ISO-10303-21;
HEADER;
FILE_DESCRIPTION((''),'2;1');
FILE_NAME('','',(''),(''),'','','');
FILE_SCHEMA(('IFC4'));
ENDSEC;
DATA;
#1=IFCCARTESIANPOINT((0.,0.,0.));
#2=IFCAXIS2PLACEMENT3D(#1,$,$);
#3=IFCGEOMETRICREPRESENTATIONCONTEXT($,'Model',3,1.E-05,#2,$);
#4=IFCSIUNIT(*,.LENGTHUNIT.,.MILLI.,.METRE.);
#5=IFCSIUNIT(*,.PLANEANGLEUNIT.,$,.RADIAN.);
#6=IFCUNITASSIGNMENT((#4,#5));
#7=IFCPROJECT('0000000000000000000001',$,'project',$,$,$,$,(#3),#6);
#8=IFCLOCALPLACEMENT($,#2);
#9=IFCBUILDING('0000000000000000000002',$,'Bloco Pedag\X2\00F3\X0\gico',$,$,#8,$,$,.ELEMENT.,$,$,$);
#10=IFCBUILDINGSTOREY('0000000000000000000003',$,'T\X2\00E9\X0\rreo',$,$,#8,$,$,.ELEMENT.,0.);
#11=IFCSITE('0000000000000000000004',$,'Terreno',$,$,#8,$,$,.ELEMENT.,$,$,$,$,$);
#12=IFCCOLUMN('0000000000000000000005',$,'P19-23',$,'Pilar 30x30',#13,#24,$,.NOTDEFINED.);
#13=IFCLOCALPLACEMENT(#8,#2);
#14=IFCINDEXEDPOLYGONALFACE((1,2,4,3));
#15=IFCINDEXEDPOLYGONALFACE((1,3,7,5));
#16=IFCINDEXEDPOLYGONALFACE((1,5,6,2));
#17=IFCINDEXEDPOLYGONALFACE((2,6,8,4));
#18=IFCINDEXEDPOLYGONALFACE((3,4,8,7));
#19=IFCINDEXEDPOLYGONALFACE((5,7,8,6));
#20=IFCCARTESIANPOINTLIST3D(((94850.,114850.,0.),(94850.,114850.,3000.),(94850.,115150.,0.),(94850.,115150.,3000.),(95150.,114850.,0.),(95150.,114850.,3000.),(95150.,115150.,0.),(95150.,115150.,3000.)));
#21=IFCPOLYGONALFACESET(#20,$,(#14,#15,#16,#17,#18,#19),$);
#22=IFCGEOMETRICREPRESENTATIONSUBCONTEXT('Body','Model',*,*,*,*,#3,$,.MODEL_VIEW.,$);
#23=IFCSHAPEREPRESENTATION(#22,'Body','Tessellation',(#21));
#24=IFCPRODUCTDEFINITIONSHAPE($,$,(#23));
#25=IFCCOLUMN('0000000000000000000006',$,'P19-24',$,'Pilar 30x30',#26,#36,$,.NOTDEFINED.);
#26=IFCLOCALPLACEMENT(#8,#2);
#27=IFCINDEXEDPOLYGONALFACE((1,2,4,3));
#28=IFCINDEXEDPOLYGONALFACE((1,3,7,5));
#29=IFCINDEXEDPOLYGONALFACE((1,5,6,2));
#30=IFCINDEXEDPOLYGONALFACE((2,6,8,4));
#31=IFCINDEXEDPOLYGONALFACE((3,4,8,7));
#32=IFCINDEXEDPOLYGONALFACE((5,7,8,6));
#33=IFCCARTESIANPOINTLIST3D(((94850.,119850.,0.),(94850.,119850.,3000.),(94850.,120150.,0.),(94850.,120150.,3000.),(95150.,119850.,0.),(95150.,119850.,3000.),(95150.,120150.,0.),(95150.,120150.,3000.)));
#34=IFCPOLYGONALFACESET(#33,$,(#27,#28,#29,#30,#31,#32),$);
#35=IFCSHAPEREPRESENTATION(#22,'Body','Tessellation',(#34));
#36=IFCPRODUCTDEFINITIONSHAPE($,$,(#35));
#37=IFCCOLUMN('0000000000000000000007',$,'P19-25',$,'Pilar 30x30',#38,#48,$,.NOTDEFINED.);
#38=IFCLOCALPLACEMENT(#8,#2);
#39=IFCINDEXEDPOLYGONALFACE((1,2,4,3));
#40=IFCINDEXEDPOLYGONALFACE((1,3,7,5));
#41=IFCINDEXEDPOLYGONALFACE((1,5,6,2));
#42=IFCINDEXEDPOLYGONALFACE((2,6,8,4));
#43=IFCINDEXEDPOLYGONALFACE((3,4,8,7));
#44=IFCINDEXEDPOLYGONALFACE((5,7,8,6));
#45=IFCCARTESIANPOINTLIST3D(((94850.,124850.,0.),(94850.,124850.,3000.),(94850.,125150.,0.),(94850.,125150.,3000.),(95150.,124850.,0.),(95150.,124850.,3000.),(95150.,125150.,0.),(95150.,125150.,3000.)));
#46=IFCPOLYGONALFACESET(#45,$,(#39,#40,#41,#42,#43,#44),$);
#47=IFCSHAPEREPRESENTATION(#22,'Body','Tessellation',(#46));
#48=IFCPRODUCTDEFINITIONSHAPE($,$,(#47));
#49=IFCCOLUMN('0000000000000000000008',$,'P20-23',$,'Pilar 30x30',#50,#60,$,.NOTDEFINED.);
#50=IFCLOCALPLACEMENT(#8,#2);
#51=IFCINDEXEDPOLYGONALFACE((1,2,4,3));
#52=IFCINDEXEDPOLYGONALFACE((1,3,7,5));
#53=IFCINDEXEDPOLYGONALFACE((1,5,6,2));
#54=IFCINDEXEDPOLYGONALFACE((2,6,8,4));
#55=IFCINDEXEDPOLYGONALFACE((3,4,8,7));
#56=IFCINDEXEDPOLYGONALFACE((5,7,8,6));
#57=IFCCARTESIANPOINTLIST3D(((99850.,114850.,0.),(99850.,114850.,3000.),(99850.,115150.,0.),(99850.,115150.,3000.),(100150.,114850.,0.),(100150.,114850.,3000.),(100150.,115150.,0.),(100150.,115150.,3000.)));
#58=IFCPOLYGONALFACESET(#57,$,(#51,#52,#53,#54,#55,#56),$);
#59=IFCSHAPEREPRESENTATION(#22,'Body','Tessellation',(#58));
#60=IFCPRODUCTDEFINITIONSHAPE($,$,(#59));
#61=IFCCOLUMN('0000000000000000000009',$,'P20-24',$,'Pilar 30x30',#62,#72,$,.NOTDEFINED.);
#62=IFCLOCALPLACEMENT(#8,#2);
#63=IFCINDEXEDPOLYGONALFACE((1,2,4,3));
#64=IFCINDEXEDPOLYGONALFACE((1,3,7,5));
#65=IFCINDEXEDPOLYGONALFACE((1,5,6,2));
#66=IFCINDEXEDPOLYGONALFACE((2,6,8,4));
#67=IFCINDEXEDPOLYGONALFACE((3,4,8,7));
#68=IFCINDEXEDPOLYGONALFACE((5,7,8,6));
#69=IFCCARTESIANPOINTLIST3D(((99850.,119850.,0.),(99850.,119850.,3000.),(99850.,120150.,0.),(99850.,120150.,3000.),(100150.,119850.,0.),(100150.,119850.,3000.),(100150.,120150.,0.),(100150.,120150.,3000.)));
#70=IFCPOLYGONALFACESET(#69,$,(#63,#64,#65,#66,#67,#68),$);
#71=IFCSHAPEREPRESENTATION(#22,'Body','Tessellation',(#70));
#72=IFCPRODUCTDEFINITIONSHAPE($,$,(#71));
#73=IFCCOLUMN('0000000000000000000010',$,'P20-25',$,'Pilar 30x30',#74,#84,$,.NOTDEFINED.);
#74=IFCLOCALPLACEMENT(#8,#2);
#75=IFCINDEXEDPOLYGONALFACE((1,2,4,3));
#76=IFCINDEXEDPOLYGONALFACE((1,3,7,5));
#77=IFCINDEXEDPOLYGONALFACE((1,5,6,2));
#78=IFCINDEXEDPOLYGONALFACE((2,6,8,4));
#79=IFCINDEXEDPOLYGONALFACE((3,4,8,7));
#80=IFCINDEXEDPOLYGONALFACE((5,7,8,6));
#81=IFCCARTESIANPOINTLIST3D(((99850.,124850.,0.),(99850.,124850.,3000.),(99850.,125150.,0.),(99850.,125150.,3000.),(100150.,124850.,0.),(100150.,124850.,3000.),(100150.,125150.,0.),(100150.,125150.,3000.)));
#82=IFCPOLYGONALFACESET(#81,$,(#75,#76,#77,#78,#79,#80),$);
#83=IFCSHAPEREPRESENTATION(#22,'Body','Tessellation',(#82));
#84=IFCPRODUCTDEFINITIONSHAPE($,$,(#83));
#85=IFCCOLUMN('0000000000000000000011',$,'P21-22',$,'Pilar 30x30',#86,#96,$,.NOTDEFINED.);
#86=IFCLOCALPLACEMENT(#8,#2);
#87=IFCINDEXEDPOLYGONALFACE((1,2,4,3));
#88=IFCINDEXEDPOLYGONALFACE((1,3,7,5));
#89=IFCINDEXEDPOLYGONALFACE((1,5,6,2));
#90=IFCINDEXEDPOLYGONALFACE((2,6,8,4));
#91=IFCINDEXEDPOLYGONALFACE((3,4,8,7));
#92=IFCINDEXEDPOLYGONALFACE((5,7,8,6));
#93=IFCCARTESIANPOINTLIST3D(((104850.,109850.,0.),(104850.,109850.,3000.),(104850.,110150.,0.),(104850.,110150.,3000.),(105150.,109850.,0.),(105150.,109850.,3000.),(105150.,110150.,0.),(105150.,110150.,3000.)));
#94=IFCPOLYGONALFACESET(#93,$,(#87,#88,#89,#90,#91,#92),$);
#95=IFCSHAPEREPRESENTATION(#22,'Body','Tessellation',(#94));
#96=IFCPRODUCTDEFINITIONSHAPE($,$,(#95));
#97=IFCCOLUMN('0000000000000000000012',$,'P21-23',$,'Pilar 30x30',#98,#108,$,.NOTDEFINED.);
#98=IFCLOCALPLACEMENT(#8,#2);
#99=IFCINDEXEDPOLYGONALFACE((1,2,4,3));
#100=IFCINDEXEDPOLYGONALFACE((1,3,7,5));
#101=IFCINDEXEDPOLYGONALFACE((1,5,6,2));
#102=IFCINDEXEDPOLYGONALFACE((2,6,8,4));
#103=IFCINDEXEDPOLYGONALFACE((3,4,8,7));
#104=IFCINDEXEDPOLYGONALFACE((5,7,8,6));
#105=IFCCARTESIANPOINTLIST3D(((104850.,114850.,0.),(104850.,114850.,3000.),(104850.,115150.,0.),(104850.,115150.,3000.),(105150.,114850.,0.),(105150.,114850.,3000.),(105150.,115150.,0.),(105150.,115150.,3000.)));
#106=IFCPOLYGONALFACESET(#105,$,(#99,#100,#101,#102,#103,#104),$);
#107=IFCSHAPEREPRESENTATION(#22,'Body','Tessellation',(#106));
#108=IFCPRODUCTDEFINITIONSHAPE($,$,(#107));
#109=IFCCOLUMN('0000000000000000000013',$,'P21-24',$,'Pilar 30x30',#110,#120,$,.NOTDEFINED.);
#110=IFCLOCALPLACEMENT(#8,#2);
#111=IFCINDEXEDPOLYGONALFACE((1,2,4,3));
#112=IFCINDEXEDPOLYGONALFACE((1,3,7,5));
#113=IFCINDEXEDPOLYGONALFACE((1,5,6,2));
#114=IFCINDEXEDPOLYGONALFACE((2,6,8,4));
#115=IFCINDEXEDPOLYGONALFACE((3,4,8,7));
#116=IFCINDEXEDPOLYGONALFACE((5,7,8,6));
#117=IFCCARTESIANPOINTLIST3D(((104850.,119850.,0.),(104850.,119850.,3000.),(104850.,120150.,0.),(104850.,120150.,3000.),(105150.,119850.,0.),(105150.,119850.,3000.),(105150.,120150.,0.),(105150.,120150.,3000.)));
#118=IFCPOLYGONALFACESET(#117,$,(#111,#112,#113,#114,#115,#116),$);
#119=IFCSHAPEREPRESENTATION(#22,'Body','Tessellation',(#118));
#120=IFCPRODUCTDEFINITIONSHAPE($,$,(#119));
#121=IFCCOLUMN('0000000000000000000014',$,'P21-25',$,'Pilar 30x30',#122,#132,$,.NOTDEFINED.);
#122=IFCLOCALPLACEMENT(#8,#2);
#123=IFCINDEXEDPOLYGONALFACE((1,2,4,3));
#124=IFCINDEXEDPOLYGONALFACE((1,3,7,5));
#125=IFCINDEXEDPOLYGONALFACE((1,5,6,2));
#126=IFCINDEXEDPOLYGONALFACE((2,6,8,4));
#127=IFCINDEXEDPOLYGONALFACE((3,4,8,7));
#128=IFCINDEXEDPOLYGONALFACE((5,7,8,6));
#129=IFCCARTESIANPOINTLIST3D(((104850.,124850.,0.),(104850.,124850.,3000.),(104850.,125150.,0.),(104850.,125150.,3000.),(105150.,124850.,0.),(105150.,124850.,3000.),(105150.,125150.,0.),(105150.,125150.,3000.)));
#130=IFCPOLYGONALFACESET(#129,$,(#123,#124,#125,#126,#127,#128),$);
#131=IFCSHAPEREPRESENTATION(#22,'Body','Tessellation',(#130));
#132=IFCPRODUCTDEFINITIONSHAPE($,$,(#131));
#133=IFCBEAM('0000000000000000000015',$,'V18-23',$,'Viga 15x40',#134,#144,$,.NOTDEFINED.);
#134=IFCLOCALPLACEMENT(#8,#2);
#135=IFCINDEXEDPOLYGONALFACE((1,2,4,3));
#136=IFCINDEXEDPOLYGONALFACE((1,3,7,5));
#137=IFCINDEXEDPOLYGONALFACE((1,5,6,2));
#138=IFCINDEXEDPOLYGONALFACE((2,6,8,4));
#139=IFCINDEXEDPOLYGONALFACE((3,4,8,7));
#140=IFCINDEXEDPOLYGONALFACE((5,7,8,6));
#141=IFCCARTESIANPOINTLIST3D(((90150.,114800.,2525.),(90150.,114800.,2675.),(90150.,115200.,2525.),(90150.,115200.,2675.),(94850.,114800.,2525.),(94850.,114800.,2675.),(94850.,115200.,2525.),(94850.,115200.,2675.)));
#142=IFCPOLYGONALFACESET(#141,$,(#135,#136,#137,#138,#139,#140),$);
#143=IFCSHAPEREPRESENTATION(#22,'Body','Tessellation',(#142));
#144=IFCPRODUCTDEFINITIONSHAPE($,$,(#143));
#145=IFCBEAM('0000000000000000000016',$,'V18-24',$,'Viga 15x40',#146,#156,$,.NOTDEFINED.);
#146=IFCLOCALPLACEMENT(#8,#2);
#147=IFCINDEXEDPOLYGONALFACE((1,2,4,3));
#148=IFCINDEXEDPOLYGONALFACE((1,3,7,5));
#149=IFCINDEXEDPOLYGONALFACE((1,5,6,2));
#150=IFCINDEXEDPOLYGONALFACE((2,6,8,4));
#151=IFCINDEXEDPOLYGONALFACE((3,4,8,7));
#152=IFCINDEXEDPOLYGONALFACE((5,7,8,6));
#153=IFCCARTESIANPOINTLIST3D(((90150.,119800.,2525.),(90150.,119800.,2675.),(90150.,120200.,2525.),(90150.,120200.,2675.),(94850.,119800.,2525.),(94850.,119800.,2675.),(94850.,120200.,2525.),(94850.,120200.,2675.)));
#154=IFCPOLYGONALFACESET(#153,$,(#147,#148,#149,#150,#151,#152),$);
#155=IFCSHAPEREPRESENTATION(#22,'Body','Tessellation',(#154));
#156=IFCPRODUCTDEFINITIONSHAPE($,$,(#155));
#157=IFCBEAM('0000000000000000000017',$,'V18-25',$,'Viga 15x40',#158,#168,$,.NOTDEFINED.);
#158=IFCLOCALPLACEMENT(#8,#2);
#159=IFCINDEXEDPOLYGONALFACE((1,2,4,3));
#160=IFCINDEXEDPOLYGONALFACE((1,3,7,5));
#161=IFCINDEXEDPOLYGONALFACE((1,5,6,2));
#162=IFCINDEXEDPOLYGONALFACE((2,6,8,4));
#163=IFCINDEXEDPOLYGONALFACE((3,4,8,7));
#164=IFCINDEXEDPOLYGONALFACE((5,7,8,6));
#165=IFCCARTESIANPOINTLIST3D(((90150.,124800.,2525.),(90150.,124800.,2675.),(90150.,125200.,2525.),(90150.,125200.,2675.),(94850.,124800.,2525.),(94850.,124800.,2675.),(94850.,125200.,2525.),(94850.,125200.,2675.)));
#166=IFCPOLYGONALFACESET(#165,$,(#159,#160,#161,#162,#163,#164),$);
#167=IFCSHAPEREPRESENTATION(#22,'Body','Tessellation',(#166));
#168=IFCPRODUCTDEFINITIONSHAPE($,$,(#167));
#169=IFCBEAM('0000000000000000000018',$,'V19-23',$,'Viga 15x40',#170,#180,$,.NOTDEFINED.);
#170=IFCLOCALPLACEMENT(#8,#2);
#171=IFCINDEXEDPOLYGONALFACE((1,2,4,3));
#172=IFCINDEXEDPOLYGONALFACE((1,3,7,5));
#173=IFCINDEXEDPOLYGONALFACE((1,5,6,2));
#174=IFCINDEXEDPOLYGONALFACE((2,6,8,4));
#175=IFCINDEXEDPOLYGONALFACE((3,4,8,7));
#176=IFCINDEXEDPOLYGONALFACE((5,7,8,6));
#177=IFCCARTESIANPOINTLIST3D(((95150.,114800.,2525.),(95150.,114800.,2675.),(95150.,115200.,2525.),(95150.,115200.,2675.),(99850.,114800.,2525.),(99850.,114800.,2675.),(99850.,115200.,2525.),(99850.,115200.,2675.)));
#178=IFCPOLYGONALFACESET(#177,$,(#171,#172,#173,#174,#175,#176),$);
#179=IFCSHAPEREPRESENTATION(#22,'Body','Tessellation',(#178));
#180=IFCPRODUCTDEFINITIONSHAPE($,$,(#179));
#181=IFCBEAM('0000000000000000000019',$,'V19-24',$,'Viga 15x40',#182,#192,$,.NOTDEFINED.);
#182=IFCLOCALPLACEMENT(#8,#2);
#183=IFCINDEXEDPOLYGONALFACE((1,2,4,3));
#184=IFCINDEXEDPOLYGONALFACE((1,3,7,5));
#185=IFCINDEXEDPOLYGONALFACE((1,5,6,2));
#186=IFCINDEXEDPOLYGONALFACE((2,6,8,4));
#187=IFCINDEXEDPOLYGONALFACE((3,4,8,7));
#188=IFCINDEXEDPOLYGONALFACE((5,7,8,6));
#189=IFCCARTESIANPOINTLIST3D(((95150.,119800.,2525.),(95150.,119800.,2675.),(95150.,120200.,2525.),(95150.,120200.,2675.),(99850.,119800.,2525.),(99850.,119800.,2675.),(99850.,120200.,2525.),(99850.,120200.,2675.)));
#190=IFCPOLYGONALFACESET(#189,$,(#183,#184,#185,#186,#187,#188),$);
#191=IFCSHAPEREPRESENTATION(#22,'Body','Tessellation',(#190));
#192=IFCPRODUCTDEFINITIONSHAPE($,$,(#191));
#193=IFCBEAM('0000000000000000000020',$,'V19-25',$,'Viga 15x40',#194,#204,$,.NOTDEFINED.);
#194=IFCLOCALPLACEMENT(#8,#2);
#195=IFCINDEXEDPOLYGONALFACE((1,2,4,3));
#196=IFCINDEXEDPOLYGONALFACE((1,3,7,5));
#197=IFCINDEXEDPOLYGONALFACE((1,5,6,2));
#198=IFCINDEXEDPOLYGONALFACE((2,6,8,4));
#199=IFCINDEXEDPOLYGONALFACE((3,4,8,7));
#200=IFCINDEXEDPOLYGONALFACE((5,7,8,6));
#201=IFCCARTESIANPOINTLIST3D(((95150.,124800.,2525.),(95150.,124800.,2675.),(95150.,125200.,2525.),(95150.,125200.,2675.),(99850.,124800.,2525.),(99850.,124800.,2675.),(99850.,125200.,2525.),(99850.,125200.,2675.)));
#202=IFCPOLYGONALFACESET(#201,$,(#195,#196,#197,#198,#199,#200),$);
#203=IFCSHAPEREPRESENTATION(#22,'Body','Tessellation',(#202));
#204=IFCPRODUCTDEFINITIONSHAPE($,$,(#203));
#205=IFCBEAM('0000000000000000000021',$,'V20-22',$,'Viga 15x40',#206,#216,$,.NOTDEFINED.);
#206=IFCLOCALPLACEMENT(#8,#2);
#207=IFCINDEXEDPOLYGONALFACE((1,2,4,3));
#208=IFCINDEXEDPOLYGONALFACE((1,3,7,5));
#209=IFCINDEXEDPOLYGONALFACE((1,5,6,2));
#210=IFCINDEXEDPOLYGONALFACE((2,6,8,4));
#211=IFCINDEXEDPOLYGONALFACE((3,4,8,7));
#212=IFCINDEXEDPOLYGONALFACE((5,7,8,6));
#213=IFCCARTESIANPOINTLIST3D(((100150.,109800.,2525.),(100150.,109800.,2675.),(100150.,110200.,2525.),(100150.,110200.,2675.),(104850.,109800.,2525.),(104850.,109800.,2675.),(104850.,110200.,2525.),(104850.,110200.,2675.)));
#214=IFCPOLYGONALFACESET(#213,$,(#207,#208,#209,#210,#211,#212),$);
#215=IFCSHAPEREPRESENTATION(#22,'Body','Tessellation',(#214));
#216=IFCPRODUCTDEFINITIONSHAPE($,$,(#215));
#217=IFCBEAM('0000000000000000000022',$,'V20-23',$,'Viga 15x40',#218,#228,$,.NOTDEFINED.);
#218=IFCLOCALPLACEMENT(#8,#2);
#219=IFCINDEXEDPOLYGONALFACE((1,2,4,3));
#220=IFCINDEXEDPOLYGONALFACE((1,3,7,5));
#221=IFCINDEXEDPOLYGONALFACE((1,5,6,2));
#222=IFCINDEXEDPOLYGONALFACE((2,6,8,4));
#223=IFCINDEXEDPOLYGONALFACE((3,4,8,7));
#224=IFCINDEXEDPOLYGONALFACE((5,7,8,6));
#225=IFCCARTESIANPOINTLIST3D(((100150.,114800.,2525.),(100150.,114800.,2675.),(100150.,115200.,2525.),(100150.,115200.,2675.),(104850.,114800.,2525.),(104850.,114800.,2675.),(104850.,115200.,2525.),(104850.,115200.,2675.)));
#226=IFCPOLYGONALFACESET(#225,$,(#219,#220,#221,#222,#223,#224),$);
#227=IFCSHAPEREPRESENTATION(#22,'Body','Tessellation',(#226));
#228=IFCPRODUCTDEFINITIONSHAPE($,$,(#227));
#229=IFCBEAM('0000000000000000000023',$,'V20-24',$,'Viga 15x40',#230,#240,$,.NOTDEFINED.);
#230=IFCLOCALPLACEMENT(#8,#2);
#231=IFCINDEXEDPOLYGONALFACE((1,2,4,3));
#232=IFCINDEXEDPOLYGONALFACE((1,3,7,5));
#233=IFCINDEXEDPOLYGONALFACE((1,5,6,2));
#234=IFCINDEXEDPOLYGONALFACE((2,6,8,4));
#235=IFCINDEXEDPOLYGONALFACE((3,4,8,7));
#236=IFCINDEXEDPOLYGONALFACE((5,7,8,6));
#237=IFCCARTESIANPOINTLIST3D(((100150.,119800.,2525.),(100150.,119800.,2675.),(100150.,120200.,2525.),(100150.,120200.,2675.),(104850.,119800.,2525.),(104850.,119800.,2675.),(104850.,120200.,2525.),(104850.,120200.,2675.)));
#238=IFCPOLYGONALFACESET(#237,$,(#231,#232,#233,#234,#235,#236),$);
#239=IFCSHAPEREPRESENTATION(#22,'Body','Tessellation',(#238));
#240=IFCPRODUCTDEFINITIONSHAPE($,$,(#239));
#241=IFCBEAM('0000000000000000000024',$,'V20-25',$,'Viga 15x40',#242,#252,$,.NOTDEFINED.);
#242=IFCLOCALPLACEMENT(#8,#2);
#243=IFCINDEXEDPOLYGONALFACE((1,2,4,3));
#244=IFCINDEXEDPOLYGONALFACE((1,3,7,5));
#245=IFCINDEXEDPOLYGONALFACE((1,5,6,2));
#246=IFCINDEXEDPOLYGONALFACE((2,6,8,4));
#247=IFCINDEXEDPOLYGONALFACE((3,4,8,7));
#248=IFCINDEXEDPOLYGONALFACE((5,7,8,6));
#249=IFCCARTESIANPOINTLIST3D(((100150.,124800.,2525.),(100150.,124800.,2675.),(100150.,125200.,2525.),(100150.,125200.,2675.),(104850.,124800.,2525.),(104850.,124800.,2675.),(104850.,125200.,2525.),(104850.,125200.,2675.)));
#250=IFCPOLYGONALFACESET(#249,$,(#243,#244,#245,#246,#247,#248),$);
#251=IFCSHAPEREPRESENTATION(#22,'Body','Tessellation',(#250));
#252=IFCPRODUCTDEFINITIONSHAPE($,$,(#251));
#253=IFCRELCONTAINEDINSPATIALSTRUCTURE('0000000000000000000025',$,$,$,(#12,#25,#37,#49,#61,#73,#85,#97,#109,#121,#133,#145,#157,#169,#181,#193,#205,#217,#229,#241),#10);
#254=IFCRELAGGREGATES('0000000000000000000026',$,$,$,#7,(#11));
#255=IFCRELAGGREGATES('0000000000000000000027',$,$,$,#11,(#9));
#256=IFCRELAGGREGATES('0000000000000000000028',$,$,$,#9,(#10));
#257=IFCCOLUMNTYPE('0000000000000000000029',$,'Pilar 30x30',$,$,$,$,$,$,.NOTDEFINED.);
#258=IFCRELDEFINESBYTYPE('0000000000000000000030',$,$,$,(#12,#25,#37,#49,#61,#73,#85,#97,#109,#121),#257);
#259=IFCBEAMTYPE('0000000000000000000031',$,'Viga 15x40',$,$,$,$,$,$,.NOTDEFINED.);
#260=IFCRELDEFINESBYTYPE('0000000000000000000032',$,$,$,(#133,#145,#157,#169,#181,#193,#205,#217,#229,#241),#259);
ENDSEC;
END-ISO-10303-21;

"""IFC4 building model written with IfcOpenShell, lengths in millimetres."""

from ifc_helpers import new_model, si_unit, frame, origin, origin_2d, place, context, subcontext, project, spatial, rectangle, extrude, type_object, element, save


model = new_model("IFC4")

# Units and contexts
model_context = context("Model", 3, precision=1e-05, world=origin())
body_context = subcontext(model_context, "Body", "Model", "MODEL_VIEW")
ifc_project = project(units=[si_unit("LENGTHUNIT", "METRE", prefix="MILLI"), si_unit("PLANEANGLEUNIT", "RADIAN")], contexts=[model_context])

# Site, building, storey
placement = place(None, origin())
site = spatial("IfcSite", under=ifc_project, at=placement, Name="Terreno", CompositionType="ELEMENT")
building = spatial("IfcBuilding", under=site, at=placement, Name="Bloco Pedagógico", CompositionType="ELEMENT")
storey = spatial("IfcBuildingStorey", under=building, at=placement, Name="Térreo", CompositionType="ELEMENT", Elevation=0.0)

# Columns
column_type = type_object("IfcColumnType", Name="Pilar 30x30", PredefinedType="NOTDEFINED")
for number, where, z_axis, x_axis, name in (
    (1, (95000.0, 115000.0, 0.0), (0.0, 0.0, 1.0), (1.0, 0.0, 0.0), "P19-23"),
    (2, (95000.0, 120000.0, 0.0), (0.0, 0.0, 1.0), (1.0, 0.0, 0.0), "P19-24"),
    (3, (95000.0, 125000.0, 0.0), (0.0, 0.0, 1.0), (1.0, 0.0, 0.0), "P19-25"),
    (4, (100000.0, 115000.0, 0.0), (0.0, 0.0, 1.0), (1.0, 0.0, 0.0), "P20-23"),
    (5, (100000.0, 120000.0, 0.0), (0.0, 0.0, 1.0), (1.0, 0.0, 0.0), "P20-24"),
    (6, (100000.0, 125000.0, 0.0), (0.0, 0.0, 1.0), (1.0, 0.0, 0.0), "P20-25"),
    (7, (105000.0, 110000.0, 0.0), (0.0, 0.0, 1.0), (1.0, 0.0, 0.0), "P21-22"),
    (8, (105000.0, 115000.0, 0.0), (0.0, 0.0, 1.0), (1.0, 0.0, 0.0), "P21-23"),
    (9, (105000.0, 120000.0, 0.0), (0.0, 0.0, 1.0), (1.0, 0.0, 0.0), "P21-24"),
    (10, (105000.0, 125000.0, 0.0), (0.0, 0.0, 1.0), (1.0, 0.0, 0.0), "P21-25"),
):
    element("IfcColumn", number, at=place(None, frame(where, z_axis=z_axis, x_axis=x_axis)), inside=storey, type_object=column_type, Name=name, ObjectType="Pilar 30x30", PredefinedType="NOTDEFINED", context=body_context, shape_type="SweptSolid", body=[
        extrude(rectangle(XDim=300.0, YDim=300.0, at=origin_2d()), None, (0.0, 0.0, 1.0), 3000.0),
    ])

# Beams
beam_type = type_object("IfcBeamType", Name="Viga 15x40", PredefinedType="NOTDEFINED")
for number, where, z_axis, x_axis, name in (
    (11, (90150.0, 115000.0, 2600.0), (1.0, 0.0, 0.0), (0.0, 1.0, 0.0), "V18-23"),
    (12, (90150.0, 120000.0, 2600.0), (1.0, 0.0, 0.0), (0.0, 1.0, 0.0), "V18-24"),
    (13, (90150.0, 125000.0, 2600.0), (1.0, 0.0, 0.0), (0.0, 1.0, 0.0), "V18-25"),
    (14, (95150.0, 115000.0, 2600.0), (1.0, 0.0, 0.0), (0.0, 1.0, 0.0), "V19-23"),
    (15, (95150.0, 120000.0, 2600.0), (1.0, 0.0, 0.0), (0.0, 1.0, 0.0), "V19-24"),
    (16, (95150.0, 125000.0, 2600.0), (1.0, 0.0, 0.0), (0.0, 1.0, 0.0), "V19-25"),
    (17, (100150.0, 110000.0, 2600.0), (1.0, 0.0, 0.0), (0.0, 1.0, 0.0), "V20-22"),
    (18, (100150.0, 115000.0, 2600.0), (1.0, 0.0, 0.0), (0.0, 1.0, 0.0), "V20-23"),
    (19, (100150.0, 120000.0, 2600.0), (1.0, 0.0, 0.0), (0.0, 1.0, 0.0), "V20-24"),
    (20, (100150.0, 125000.0, 2600.0), (1.0, 0.0, 0.0), (0.0, 1.0, 0.0), "V20-25"),
):
    element("IfcBeam", number, at=place(None, frame(where, z_axis=z_axis, x_axis=x_axis)), inside=storey, type_object=beam_type, Name=name, ObjectType="Viga 15x40", PredefinedType="NOTDEFINED", context=body_context, shape_type="SweptSolid", body=[
        extrude(rectangle(XDim=400.0, YDim=150.0, at=origin_2d()), None, (0.0, 0.0, 1.0), 4700.0),
    ])

save(model, "model.ifc")
